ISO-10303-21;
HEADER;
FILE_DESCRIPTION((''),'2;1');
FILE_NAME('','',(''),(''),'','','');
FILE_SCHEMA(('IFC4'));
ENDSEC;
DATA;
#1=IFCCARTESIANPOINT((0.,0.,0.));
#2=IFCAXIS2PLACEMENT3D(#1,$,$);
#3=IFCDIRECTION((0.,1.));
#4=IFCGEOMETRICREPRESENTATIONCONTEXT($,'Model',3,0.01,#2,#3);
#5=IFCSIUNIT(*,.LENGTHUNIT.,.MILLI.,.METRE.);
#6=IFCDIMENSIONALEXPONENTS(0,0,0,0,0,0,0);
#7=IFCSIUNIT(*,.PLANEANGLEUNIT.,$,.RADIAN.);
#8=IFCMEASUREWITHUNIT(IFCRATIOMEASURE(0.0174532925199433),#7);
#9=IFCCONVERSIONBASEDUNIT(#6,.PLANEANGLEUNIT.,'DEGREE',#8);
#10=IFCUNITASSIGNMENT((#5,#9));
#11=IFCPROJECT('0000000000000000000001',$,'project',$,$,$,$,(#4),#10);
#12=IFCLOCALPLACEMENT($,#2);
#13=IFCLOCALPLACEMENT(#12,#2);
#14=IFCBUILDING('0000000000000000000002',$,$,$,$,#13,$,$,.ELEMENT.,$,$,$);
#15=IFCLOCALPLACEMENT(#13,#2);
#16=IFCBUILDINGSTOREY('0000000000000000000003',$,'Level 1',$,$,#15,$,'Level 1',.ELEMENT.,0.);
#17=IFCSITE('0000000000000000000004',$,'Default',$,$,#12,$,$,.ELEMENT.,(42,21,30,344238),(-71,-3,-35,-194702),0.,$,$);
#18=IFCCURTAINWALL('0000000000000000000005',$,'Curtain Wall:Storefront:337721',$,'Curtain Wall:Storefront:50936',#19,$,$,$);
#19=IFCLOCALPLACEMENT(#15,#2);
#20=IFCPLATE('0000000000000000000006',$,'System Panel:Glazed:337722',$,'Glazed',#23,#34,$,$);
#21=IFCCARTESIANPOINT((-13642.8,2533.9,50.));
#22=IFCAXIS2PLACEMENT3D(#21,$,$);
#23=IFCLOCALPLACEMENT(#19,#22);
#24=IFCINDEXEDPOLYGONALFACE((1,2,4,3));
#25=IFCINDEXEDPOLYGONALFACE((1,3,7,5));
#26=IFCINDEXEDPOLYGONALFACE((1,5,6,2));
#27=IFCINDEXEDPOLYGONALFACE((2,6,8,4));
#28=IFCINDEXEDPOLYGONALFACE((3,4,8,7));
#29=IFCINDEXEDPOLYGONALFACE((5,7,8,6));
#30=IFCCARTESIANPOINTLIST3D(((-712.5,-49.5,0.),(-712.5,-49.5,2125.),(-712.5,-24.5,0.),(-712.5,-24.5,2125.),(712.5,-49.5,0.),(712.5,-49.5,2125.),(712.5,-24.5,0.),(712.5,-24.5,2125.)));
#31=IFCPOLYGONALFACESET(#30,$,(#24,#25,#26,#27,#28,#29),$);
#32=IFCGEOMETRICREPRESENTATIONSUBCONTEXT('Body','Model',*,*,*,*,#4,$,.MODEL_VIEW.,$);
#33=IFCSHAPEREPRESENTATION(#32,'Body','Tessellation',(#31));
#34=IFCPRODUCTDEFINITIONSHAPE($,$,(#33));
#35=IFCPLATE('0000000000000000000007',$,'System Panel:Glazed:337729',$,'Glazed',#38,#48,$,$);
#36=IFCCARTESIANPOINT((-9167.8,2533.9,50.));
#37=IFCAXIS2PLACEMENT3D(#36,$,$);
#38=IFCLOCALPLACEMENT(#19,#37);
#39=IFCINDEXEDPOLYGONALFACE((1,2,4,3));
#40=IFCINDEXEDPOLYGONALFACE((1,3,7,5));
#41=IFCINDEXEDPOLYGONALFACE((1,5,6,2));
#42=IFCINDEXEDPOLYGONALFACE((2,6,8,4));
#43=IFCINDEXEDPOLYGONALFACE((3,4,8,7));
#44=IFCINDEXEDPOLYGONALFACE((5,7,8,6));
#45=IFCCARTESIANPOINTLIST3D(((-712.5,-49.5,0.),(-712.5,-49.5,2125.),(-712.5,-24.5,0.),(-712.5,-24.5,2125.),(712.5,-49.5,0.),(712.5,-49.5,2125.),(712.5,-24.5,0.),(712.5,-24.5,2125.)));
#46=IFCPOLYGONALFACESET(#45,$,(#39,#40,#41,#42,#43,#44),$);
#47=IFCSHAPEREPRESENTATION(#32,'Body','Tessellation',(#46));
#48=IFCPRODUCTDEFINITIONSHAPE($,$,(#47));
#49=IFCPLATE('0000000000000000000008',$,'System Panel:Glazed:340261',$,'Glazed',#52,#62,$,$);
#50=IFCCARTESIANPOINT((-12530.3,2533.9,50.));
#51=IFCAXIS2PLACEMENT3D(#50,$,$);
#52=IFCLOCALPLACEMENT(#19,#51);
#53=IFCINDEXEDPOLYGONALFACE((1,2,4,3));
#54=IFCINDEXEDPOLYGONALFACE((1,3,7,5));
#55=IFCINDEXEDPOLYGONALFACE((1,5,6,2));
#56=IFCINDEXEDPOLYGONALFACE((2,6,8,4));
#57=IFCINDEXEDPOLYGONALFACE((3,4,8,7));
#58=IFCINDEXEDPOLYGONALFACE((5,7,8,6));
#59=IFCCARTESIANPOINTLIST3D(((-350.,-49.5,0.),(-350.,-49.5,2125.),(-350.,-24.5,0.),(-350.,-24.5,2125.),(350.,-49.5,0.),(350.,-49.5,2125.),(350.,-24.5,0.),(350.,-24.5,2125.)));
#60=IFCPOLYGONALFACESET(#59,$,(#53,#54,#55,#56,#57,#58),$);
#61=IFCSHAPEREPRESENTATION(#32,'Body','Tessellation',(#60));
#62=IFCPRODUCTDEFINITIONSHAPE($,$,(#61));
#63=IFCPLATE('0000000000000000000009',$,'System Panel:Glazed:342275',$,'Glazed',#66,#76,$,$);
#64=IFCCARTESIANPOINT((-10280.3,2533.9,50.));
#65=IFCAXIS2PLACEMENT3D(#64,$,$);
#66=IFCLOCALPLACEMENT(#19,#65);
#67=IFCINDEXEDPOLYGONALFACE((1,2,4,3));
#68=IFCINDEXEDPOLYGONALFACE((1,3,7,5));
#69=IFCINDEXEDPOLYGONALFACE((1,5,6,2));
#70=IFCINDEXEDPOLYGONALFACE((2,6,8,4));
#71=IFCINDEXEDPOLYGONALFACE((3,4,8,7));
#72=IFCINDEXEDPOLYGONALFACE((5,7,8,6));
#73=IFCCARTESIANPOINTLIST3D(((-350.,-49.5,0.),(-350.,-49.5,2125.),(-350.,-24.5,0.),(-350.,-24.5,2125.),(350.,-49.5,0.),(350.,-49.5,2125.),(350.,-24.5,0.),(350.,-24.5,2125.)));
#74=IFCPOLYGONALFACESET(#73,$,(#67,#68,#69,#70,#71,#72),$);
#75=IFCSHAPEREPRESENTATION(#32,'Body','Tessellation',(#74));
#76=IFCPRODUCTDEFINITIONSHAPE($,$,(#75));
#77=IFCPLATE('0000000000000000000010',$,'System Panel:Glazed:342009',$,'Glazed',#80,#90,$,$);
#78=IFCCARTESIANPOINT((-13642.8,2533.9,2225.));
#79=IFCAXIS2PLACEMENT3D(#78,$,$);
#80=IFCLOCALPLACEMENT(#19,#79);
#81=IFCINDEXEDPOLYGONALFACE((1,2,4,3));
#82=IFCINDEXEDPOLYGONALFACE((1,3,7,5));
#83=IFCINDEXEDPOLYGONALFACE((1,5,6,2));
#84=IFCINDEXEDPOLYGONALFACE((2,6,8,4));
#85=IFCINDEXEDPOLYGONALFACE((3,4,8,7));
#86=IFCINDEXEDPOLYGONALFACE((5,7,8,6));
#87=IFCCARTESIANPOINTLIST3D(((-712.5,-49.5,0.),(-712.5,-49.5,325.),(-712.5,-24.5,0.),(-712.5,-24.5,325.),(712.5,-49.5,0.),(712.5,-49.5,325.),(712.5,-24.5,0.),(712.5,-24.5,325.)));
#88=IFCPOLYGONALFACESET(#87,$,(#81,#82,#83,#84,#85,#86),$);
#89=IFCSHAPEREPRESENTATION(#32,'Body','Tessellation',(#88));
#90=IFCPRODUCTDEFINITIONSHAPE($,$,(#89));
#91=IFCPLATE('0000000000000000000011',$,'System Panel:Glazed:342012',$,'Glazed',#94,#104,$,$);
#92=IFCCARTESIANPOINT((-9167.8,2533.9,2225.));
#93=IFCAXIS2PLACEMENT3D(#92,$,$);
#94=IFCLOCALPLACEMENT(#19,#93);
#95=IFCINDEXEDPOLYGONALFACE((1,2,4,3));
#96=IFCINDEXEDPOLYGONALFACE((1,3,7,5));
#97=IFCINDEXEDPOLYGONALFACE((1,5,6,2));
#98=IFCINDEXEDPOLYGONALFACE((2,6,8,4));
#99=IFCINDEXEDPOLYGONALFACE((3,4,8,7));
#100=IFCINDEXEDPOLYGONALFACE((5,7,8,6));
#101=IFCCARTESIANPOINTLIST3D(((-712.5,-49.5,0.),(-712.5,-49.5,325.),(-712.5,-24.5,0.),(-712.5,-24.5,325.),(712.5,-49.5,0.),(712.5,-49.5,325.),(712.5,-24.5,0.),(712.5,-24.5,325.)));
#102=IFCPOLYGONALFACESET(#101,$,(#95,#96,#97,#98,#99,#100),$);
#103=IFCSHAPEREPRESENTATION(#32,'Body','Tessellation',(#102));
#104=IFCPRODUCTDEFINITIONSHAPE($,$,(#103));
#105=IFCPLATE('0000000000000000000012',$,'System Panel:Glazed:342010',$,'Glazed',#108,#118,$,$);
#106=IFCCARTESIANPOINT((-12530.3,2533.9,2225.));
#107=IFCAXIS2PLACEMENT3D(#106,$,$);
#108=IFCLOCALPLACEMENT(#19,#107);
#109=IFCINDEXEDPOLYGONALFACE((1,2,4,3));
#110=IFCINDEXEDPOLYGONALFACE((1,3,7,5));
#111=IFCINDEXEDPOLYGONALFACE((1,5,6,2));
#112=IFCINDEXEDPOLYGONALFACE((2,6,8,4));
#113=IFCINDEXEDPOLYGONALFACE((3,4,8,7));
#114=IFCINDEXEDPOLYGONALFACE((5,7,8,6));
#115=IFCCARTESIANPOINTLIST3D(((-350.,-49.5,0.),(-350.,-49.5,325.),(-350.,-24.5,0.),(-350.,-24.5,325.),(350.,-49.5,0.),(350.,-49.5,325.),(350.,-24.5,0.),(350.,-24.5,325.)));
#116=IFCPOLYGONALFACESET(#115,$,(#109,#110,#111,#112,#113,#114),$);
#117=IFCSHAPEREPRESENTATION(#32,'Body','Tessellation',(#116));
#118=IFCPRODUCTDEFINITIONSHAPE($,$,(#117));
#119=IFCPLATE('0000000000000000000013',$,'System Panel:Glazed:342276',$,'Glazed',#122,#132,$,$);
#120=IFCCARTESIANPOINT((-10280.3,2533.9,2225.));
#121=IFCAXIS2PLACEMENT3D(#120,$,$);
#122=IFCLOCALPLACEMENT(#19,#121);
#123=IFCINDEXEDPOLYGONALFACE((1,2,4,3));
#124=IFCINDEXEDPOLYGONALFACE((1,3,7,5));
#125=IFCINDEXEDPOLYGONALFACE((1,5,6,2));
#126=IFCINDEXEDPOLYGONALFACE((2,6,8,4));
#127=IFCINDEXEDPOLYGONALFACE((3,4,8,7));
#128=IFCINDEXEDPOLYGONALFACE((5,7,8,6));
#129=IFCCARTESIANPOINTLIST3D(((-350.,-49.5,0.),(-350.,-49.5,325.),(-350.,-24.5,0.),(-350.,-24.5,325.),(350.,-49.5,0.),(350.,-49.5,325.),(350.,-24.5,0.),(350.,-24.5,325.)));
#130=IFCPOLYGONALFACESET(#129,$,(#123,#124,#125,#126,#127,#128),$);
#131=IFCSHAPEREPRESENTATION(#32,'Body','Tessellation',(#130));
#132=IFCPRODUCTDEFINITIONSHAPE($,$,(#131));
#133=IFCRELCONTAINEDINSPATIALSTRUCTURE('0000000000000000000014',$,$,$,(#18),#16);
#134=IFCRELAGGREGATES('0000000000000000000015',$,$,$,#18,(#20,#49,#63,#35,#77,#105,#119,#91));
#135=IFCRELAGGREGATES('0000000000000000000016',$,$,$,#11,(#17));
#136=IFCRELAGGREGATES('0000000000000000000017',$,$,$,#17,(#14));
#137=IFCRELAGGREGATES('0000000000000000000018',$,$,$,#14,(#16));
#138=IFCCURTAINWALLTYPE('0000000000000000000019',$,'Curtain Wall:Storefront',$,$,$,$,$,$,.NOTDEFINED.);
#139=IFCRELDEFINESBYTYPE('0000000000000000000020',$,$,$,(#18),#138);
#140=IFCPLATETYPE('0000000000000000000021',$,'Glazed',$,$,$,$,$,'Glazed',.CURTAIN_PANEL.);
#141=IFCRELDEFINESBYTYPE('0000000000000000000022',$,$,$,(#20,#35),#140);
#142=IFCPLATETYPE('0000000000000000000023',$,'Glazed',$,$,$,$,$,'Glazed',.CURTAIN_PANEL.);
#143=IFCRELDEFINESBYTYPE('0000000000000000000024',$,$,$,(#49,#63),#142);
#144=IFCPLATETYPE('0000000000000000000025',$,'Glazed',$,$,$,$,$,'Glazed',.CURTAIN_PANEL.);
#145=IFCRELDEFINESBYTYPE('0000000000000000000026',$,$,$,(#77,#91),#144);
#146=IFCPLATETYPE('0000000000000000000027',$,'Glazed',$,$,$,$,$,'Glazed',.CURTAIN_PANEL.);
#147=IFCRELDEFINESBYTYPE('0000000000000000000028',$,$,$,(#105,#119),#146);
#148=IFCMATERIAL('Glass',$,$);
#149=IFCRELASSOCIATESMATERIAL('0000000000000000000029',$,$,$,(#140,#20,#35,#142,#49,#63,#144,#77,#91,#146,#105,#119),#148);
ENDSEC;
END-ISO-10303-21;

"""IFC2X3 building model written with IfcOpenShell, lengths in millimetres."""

from ifc_helpers import new_model, entity, si_unit, converted_unit, direction, frame, frame_2d, origin, place, context, subcontext, project, spatial, rectangle, extrude, source, transform, mapped, material, type_object, type_shapes, element, aggregate, save


model = new_model("IFC2X3")

# Units and contexts
model_context = context("Model", 3, precision=0.01, world=origin(), true_north=direction((0.0, 1.0)))
body_context = subcontext(model_context, "Body", "Model", "MODEL_VIEW")
ifc_project = project(units=[si_unit("LENGTHUNIT", "METRE", prefix="MILLI"), converted_unit("PLANEANGLEUNIT", "DEGREE", entity("IfcRatioMeasure", 0.0174532925199433), si_unit("PLANEANGLEUNIT", "RADIAN"), dimensions=[0, 0, 0, 0, 0, 0, 0])], contexts=[model_context])

# Site, building, storey
site_placement = place(None, origin())
site = spatial("IfcSite", under=ifc_project, at=site_placement, Name="Default", CompositionType="ELEMENT", RefLatitude=(42, 21, 30, 344238), RefLongitude=(-71, -3, -35, -194702), RefElevation=0.0)
building_placement = place(site_placement, origin())
building = spatial("IfcBuilding", under=site, at=building_placement, CompositionType="ELEMENT")
storey_placement = place(building_placement, origin())
storey = spatial("IfcBuildingStorey", under=building, at=storey_placement, Name="Level 1", LongName="Level 1", CompositionType="ELEMENT", Elevation=0.0)

# Curtain wall, plates
curtain_wall_type = type_object("IfcCurtainWallType", Name="Curtain Wall:Storefront", PredefinedType="NOTDEFINED")
curtain_wall_placement = place(storey_placement, origin())
curtain_wall = element("IfcCurtainWall", 1, at=curtain_wall_placement, inside=storey, type_object=curtain_wall_type, Name="Curtain Wall:Storefront:337721", ObjectType="Curtain Wall:Storefront:50936")
ifc_material_1 = material(Name="Glass")
plate_type_1 = type_object("IfcPlateType", Name="Glazed", ElementType="Glazed", PredefinedType="CURTAIN_PANEL", material=ifc_material_1)
shared_shape_1 = source(origin(), body_context, "Body", "SweptSolid", [
    extrude(rectangle(XDim=25.0, YDim=1425.0, at=frame_2d((0.0, 0.0), x_axis=(1.0, 0.0))), frame((0.0, -37.0, 0.0), z_axis=(0.0, 0.0, 1.0), x_axis=(0.0, 1.0, 0.0)), (0.0, 0.0, 1.0), 2125.0),
])
type_shapes(plate_type_1, [shared_shape_1])
plate_1_placement = place(curtain_wall_placement, frame((-13642.8, 2533.9, 50.0)))
plate_1 = element("IfcPlate", 2, at=plate_1_placement, type_object=plate_type_1, material=ifc_material_1, Name="System Panel:Glazed:337722", ObjectType="Glazed", context=body_context, shape_type="MappedRepresentation", body=[
    mapped(shared_shape_1, transform((0.0, 0.0, 0.0), scale=1.0)),
])
plate_2_placement = place(curtain_wall_placement, frame((-9167.8, 2533.9, 50.0)))
plate_2 = element("IfcPlate", 3, at=plate_2_placement, type_object=plate_type_1, material=ifc_material_1, Name="System Panel:Glazed:337729", ObjectType="Glazed", context=body_context, shape_type="MappedRepresentation", body=[
    mapped(shared_shape_1, transform((0.0, 0.0, 0.0), scale=1.0)),
])
plate_type_2 = type_object("IfcPlateType", Name="Glazed", ElementType="Glazed", PredefinedType="CURTAIN_PANEL", material=ifc_material_1)
shared_shape_2 = source(origin(), body_context, "Body", "SweptSolid", [
    extrude(rectangle(XDim=25.0, YDim=700.0, at=frame_2d((0.0, 0.0), x_axis=(1.0, 0.0))), frame((0.0, -37.0, 0.0), z_axis=(0.0, 0.0, 1.0), x_axis=(0.0, 1.0, 0.0)), (0.0, 0.0, 1.0), 2125.0),
])
type_shapes(plate_type_2, [shared_shape_2])
plate_3_placement = place(curtain_wall_placement, frame((-12530.3, 2533.9, 50.0)))
plate_3 = element("IfcPlate", 4, at=plate_3_placement, type_object=plate_type_2, material=ifc_material_1, Name="System Panel:Glazed:340261", ObjectType="Glazed", context=body_context, shape_type="MappedRepresentation", body=[
    mapped(shared_shape_2, transform((0.0, 0.0, 0.0), scale=1.0)),
])
plate_4_placement = place(curtain_wall_placement, frame((-10280.3, 2533.9, 50.0)))
plate_4 = element("IfcPlate", 5, at=plate_4_placement, type_object=plate_type_2, material=ifc_material_1, Name="System Panel:Glazed:342275", ObjectType="Glazed", context=body_context, shape_type="MappedRepresentation", body=[
    mapped(shared_shape_2, transform((0.0, 0.0, 0.0), scale=1.0)),
])
plate_type_3 = type_object("IfcPlateType", Name="Glazed", ElementType="Glazed", PredefinedType="CURTAIN_PANEL", material=ifc_material_1)
shared_shape_3 = source(origin(), body_context, "Body", "SweptSolid", [
    extrude(rectangle(XDim=25.0, YDim=1425.0, at=frame_2d((0.0, 0.0), x_axis=(1.0, 0.0))), frame((0.0, -37.0, 0.0), z_axis=(0.0, 0.0, 1.0), x_axis=(0.0, 1.0, 0.0)), (0.0, 0.0, 1.0), 325.0),
])
type_shapes(plate_type_3, [shared_shape_3])
plate_5_placement = place(curtain_wall_placement, frame((-13642.8, 2533.9, 2225.0)))
plate_5 = element("IfcPlate", 6, at=plate_5_placement, type_object=plate_type_3, material=ifc_material_1, Name="System Panel:Glazed:342009", ObjectType="Glazed", context=body_context, shape_type="MappedRepresentation", body=[
    mapped(shared_shape_3, transform((0.0, 0.0, 0.0), scale=1.0)),
])
plate_6_placement = place(curtain_wall_placement, frame((-9167.8, 2533.9, 2225.0)))
plate_6 = element("IfcPlate", 7, at=plate_6_placement, type_object=plate_type_3, material=ifc_material_1, Name="System Panel:Glazed:342012", ObjectType="Glazed", context=body_context, shape_type="MappedRepresentation", body=[
    mapped(shared_shape_3, transform((0.0, 0.0, 0.0), scale=1.0)),
])
plate_type_4 = type_object("IfcPlateType", Name="Glazed", ElementType="Glazed", PredefinedType="CURTAIN_PANEL", material=ifc_material_1)
shared_shape_4 = source(origin(), body_context, "Body", "SweptSolid", [
    extrude(rectangle(XDim=25.0, YDim=700.0, at=frame_2d((0.0, 0.0), x_axis=(1.0, 0.0))), frame((0.0, -37.0, 0.0), z_axis=(0.0, 0.0, 1.0), x_axis=(0.0, 1.0, 0.0)), (0.0, 0.0, 1.0), 325.0),
])
type_shapes(plate_type_4, [shared_shape_4])
plate_7_placement = place(curtain_wall_placement, frame((-12530.3, 2533.9, 2225.0)))
plate_7 = element("IfcPlate", 8, at=plate_7_placement, type_object=plate_type_4, material=ifc_material_1, Name="System Panel:Glazed:342010", ObjectType="Glazed", context=body_context, shape_type="MappedRepresentation", body=[
    mapped(shared_shape_4, transform((0.0, 0.0, 0.0), scale=1.0)),
])
plate_8_placement = place(curtain_wall_placement, frame((-10280.3, 2533.9, 2225.0)))
plate_8 = element("IfcPlate", 9, at=plate_8_placement, type_object=plate_type_4, material=ifc_material_1, Name="System Panel:Glazed:342276", ObjectType="Glazed", context=body_context, shape_type="MappedRepresentation", body=[
    mapped(shared_shape_4, transform((0.0, 0.0, 0.0), scale=1.0)),
])

aggregate(curtain_wall, [plate_1, plate_3, plate_4, plate_2, plate_5, plate_7, plate_8, plate_6])

save(model, "model.ifc")
